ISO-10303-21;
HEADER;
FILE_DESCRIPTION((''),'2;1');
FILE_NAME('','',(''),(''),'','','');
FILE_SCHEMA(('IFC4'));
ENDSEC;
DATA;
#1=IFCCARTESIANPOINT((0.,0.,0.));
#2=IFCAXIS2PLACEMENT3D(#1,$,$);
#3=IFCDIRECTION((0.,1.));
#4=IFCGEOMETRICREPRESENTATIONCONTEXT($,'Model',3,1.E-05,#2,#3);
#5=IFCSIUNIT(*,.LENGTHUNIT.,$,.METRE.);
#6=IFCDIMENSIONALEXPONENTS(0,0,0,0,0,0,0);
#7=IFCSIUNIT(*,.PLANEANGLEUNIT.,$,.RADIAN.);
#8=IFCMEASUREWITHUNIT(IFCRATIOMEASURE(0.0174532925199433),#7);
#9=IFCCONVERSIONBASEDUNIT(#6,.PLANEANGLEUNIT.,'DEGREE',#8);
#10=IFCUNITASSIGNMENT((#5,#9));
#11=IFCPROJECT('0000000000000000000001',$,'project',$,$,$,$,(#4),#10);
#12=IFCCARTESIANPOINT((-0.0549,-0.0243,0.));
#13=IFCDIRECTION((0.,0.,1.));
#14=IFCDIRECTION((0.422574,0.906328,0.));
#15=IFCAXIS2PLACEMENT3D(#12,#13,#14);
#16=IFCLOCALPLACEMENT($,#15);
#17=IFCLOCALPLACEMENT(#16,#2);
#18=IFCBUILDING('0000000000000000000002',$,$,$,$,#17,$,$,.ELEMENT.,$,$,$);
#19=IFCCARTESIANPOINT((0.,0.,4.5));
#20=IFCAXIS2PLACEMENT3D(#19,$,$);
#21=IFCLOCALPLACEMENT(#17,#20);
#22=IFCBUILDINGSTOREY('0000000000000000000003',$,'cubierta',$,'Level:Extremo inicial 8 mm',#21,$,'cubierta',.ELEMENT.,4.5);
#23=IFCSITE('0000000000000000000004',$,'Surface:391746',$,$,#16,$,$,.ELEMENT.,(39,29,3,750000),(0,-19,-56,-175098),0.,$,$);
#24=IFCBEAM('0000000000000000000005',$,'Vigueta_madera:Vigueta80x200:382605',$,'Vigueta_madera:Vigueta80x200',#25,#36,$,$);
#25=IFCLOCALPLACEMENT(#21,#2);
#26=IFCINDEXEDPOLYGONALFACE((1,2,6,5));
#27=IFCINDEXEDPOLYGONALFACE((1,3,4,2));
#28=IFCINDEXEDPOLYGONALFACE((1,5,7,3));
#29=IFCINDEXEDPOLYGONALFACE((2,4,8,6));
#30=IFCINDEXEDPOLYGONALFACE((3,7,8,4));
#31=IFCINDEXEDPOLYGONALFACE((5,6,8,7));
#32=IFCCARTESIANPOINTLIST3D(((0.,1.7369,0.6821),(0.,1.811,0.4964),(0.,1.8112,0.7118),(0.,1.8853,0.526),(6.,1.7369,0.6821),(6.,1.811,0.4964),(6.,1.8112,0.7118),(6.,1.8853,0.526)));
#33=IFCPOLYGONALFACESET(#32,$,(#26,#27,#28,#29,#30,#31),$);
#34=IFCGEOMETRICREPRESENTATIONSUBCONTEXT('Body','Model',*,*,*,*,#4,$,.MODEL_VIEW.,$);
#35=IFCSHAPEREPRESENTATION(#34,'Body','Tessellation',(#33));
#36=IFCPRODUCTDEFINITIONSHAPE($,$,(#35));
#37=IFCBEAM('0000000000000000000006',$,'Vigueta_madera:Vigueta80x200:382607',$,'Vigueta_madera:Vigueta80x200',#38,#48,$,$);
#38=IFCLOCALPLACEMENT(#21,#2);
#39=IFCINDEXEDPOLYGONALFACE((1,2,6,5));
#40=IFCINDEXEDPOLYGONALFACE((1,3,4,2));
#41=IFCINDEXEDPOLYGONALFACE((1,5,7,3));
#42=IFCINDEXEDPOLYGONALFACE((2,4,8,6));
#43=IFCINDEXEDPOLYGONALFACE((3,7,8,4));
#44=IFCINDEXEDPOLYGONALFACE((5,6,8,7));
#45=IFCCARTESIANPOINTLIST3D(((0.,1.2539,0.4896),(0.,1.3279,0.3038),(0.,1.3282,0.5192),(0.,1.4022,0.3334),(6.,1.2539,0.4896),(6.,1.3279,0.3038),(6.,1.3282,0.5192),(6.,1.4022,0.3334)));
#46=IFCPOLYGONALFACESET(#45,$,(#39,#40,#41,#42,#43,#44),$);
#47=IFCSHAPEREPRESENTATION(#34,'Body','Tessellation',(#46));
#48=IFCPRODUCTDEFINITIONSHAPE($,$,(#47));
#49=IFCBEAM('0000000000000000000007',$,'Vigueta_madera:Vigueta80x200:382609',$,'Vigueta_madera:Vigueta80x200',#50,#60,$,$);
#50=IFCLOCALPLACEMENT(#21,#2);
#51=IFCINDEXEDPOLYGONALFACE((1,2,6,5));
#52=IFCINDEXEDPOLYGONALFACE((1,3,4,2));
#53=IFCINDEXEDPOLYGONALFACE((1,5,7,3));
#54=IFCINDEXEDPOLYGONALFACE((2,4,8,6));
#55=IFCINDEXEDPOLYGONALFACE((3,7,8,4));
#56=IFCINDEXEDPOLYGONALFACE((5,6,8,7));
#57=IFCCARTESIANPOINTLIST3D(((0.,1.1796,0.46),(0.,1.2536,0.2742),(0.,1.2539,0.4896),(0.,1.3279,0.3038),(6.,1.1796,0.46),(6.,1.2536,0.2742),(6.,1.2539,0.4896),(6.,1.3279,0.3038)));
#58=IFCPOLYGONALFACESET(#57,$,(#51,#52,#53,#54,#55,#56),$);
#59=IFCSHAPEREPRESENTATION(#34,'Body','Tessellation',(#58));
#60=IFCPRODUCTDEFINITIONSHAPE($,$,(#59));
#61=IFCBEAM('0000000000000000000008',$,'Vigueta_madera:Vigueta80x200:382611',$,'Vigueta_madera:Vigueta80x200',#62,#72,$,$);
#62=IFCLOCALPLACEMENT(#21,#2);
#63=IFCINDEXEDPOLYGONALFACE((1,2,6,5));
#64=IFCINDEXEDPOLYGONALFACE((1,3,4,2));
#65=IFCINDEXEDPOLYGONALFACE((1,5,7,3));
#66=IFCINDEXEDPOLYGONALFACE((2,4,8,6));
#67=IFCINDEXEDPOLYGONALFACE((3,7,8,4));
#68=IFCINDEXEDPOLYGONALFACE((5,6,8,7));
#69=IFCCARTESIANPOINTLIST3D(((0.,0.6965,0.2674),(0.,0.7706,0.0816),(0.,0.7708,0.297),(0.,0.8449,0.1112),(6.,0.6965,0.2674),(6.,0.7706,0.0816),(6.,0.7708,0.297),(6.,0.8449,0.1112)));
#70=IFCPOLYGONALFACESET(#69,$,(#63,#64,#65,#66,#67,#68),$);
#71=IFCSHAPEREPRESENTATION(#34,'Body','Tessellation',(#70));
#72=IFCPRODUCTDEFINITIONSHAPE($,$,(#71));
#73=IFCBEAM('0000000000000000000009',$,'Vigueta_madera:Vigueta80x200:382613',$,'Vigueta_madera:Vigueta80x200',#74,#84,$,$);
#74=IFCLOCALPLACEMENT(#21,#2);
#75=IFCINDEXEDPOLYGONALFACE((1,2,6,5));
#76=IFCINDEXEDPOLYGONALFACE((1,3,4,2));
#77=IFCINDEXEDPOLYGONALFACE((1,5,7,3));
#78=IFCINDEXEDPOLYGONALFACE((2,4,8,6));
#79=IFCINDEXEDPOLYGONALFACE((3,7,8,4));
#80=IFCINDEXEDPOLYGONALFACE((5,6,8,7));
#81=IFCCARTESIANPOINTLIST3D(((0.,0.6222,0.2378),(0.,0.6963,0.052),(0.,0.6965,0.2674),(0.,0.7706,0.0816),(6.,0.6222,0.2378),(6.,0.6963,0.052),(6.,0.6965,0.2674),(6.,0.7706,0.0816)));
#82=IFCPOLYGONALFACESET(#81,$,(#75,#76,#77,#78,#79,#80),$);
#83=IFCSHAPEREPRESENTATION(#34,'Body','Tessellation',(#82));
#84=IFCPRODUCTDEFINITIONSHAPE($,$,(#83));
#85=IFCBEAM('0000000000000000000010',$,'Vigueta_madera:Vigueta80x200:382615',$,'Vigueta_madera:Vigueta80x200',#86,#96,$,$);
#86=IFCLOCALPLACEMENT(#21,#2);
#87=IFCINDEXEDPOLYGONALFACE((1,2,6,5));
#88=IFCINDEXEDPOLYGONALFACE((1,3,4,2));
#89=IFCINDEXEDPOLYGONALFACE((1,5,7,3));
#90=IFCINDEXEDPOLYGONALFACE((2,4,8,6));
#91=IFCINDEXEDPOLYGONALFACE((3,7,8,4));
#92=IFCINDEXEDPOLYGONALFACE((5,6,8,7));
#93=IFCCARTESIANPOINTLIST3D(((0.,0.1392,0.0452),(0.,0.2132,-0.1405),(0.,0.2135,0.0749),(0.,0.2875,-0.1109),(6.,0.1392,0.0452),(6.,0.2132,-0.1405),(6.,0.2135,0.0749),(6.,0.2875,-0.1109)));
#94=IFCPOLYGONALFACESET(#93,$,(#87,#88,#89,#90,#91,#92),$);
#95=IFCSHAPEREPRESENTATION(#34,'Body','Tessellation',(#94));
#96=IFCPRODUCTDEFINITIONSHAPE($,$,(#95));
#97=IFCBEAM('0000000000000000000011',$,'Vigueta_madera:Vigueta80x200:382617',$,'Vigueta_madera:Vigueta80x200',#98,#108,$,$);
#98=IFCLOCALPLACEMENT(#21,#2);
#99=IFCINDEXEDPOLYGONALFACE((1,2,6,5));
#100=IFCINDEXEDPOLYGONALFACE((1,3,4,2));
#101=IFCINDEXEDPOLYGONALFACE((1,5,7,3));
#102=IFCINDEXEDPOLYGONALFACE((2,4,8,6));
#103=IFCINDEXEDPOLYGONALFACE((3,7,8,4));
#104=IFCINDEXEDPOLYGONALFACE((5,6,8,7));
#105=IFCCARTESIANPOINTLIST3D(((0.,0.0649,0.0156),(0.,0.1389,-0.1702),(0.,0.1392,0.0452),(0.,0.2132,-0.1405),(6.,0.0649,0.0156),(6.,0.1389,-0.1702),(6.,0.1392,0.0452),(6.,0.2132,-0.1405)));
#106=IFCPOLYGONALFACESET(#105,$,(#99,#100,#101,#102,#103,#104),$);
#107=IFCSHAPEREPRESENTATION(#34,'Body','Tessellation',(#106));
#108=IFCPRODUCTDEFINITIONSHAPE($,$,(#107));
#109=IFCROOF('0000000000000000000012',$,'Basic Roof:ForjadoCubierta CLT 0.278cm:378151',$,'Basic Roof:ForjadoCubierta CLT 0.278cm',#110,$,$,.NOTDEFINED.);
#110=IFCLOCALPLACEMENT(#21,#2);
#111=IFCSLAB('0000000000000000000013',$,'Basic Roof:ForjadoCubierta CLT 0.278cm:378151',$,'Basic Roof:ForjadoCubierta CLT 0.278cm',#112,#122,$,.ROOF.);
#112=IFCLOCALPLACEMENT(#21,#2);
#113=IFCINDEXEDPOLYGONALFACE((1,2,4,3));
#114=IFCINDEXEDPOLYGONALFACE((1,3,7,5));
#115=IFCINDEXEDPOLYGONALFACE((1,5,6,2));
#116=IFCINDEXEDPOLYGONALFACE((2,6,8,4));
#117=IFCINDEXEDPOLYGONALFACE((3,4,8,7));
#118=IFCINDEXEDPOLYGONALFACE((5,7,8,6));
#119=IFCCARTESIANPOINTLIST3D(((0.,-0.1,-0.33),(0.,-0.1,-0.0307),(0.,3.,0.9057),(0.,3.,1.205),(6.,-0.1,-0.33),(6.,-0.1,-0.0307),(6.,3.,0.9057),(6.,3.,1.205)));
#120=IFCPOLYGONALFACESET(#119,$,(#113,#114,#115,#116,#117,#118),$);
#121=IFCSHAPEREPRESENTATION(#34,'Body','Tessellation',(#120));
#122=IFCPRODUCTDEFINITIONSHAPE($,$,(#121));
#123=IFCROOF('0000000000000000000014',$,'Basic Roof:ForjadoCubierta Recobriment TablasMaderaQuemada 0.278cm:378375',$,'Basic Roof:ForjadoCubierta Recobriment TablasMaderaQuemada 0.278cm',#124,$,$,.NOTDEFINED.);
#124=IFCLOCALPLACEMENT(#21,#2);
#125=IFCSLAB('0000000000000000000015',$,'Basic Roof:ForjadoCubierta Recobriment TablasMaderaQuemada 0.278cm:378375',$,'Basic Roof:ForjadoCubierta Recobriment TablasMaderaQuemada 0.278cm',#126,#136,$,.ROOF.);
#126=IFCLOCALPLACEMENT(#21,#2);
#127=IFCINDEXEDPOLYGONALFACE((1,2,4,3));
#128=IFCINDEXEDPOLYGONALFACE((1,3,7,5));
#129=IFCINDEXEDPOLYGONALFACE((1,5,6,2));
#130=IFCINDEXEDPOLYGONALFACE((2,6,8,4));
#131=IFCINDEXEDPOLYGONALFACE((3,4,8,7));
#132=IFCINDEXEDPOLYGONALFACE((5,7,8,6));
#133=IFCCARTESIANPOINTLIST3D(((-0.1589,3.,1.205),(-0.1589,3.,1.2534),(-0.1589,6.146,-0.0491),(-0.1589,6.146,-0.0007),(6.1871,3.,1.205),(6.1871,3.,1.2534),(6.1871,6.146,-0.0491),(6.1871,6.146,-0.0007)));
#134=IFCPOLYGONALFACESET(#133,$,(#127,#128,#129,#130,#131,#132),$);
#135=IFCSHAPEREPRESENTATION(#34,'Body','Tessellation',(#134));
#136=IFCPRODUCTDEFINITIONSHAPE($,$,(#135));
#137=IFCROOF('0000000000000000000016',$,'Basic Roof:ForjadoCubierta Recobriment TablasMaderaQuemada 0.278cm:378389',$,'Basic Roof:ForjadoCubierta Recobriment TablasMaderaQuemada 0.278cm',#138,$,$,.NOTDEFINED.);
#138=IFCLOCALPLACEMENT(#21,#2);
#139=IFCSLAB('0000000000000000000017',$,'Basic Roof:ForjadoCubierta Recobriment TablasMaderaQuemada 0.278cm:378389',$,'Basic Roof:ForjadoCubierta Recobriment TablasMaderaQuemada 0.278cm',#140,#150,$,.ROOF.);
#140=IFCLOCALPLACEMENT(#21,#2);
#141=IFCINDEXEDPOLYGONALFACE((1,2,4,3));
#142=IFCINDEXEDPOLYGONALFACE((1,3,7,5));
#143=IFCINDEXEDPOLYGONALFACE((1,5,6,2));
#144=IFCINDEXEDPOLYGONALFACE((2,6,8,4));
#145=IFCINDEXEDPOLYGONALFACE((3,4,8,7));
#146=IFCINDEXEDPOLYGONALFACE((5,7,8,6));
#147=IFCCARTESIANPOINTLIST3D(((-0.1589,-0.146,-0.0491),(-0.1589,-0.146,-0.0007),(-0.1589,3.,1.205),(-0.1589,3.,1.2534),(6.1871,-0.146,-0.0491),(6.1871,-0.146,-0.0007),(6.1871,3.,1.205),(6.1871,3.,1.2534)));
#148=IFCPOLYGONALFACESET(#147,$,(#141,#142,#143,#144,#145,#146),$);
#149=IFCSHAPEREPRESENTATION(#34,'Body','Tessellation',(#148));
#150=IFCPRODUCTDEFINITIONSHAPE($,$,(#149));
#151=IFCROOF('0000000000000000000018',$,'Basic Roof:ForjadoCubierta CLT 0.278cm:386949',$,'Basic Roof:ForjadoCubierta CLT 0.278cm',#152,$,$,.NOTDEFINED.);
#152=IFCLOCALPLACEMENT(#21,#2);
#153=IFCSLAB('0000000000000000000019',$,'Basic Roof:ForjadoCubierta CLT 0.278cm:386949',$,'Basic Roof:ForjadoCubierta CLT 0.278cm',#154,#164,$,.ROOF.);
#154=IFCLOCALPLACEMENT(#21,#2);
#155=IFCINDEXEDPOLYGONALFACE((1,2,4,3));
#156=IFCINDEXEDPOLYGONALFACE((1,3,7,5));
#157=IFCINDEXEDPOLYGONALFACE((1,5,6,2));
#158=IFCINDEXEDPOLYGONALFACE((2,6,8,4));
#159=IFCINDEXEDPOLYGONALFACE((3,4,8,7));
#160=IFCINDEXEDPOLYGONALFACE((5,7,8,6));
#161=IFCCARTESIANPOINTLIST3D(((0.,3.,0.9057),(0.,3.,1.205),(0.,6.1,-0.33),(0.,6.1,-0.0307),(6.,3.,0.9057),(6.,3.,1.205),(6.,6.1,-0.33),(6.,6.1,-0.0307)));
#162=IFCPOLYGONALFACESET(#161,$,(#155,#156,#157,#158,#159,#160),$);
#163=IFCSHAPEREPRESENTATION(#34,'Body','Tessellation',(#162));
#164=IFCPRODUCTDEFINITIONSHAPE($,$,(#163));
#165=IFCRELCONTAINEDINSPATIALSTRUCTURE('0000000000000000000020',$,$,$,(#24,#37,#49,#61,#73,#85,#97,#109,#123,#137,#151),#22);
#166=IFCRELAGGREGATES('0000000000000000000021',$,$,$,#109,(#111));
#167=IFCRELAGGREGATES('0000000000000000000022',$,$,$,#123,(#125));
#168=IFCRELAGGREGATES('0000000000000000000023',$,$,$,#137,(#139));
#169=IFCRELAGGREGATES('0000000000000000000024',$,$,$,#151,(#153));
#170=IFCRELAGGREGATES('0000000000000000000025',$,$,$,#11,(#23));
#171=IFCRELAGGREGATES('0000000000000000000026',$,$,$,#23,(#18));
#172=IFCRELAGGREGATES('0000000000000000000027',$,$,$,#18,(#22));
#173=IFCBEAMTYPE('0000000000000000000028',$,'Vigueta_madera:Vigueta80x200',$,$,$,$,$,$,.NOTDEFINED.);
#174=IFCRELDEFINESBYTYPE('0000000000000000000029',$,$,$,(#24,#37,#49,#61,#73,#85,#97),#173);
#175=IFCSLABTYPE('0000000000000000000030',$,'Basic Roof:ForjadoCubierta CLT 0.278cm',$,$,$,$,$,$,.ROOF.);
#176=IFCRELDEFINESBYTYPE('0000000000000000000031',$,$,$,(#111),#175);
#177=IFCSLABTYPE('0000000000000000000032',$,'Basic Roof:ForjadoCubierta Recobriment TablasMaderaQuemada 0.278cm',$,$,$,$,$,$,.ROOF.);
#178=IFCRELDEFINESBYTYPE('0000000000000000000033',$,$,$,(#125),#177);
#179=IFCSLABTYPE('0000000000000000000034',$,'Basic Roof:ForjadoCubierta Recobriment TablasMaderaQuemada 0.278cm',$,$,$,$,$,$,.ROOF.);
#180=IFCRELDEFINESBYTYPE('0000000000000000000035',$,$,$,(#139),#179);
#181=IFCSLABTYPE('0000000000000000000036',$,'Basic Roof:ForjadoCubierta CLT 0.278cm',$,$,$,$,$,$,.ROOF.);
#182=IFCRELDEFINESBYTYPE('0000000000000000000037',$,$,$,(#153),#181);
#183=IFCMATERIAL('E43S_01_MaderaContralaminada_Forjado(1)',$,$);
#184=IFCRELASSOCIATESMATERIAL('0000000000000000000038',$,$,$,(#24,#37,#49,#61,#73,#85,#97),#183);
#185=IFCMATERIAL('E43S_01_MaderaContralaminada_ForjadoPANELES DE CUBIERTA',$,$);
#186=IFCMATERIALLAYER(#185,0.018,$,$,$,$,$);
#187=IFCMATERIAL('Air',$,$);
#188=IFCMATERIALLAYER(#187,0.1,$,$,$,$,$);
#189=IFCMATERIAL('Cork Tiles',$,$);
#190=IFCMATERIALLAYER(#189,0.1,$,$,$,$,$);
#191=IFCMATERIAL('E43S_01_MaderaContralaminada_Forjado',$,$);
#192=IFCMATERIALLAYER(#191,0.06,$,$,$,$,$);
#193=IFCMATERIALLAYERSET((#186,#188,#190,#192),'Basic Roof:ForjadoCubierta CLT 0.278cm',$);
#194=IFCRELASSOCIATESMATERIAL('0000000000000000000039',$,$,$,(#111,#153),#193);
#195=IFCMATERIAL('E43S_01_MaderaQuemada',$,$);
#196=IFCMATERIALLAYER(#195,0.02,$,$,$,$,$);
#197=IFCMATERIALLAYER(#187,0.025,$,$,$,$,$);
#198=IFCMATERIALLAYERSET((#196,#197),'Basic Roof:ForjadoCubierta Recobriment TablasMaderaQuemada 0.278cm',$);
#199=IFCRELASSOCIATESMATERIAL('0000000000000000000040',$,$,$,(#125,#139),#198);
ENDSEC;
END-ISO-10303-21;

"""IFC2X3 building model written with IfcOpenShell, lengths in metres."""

from ifc_helpers import new_model, entity, si_unit, converted_unit, direction, frame, frame_2d, origin, place, context, subcontext, project, spatial, rectangle, extrude, material, layer, layer_set, type_object, element, aggregate, save


model = new_model("IFC2X3")

# Units and contexts
model_context = context("Model", 3, precision=1e-05, world=origin(), true_north=direction((0.0, 1.0)))
body_context = subcontext(model_context, "Body", "Model", "MODEL_VIEW")
ifc_project = project(units=[si_unit("LENGTHUNIT", "METRE"), converted_unit("PLANEANGLEUNIT", "DEGREE", entity("IfcRatioMeasure", 0.0174532925199433), si_unit("PLANEANGLEUNIT", "RADIAN"), dimensions=[0, 0, 0, 0, 0, 0, 0])], contexts=[model_context])

# Site, building, storey
site_placement = place(None, frame((-0.0549, -0.0243, 0.0), z_axis=(0.0, 0.0, 1.0), x_axis=(0.422574, 0.906328, 0.0)))
site = spatial("IfcSite", under=ifc_project, at=site_placement, Name="Surface:391746", CompositionType="ELEMENT", RefLatitude=(39, 29, 3, 750000), RefLongitude=(0, -19, -56, -175098), RefElevation=0.0)
building_placement = place(site_placement, origin())
building = spatial("IfcBuilding", under=site, at=building_placement, CompositionType="ELEMENT")
storey_placement = place(building_placement, frame((0.0, 0.0, 4.5)))
storey = spatial("IfcBuildingStorey", under=building, at=storey_placement, Name="cubierta", ObjectType="Level:Extremo inicial 8 mm", LongName="cubierta", CompositionType="ELEMENT", Elevation=4.5)

# Beams
ifc_material_1 = material(Name="E43S_01_MaderaContralaminada_Forjado(1)")
beam_type = type_object("IfcBeamType", Name="Vigueta_madera:Vigueta80x200", PredefinedType="NOTDEFINED")
beam_1_placement = place(storey_placement, frame((0.0, 1.7741, 0.697)))
element("IfcBeam", 1, at=beam_1_placement, inside=storey, type_object=beam_type, material=ifc_material_1, Name="Vigueta_madera:Vigueta80x200:382605", ObjectType="Vigueta_madera:Vigueta80x200", context=body_context, shape_type="SweptSolid", body=[
    extrude(rectangle(XDim=0.2, YDim=0.08, at=frame_2d((0.0, 0.0), x_axis=(1.0, 0.0))), frame((0.0, 0.037, -0.0929), z_axis=(1.0, 0.0, 0.0), x_axis=(0.0, -0.370233, 0.928939)), (0.0, 0.0, 1.0), 6.0),
])
beam_2_placement = place(storey_placement, frame((0.0, 1.291, 0.5044)))
element("IfcBeam", 2, at=beam_2_placement, inside=storey, type_object=beam_type, material=ifc_material_1, Name="Vigueta_madera:Vigueta80x200:382607", ObjectType="Vigueta_madera:Vigueta80x200", context=body_context, shape_type="SweptSolid", body=[
    extrude(rectangle(XDim=0.2, YDim=0.08, at=frame_2d((0.0, 0.0), x_axis=(1.0, 0.0))), frame((0.0, 0.037, -0.0929), z_axis=(1.0, 0.0, 0.0), x_axis=(0.0, -0.370233, 0.928939)), (0.0, 0.0, 1.0), 6.0),
])
beam_3_placement = place(storey_placement, frame((0.0, 1.2167, 0.4748)))
element("IfcBeam", 3, at=beam_3_placement, inside=storey, type_object=beam_type, material=ifc_material_1, Name="Vigueta_madera:Vigueta80x200:382609", ObjectType="Vigueta_madera:Vigueta80x200", context=body_context, shape_type="SweptSolid", body=[
    extrude(rectangle(XDim=0.2, YDim=0.08, at=frame_2d((0.0, 0.0), x_axis=(1.0, 0.0))), frame((0.0, 0.037, -0.0929), z_axis=(1.0, 0.0, 0.0), x_axis=(0.0, -0.370233, 0.928939)), (0.0, 0.0, 1.0), 6.0),
])
beam_4_placement = place(storey_placement, frame((0.0, 0.7337, 0.2822)))
element("IfcBeam", 4, at=beam_4_placement, inside=storey, type_object=beam_type, material=ifc_material_1, Name="Vigueta_madera:Vigueta80x200:382611", ObjectType="Vigueta_madera:Vigueta80x200", context=body_context, shape_type="SweptSolid", body=[
    extrude(rectangle(XDim=0.2, YDim=0.08, at=frame_2d((0.0, 0.0), x_axis=(1.0, 0.0))), frame((0.0, 0.037, -0.0929), z_axis=(1.0, 0.0, 0.0), x_axis=(0.0, -0.370233, 0.928939)), (0.0, 0.0, 1.0), 6.0),
])
beam_5_placement = place(storey_placement, frame((0.0, 0.6594, 0.2526)))
element("IfcBeam", 5, at=beam_5_placement, inside=storey, type_object=beam_type, material=ifc_material_1, Name="Vigueta_madera:Vigueta80x200:382613", ObjectType="Vigueta_madera:Vigueta80x200", context=body_context, shape_type="SweptSolid", body=[
    extrude(rectangle(XDim=0.2, YDim=0.08, at=frame_2d((0.0, 0.0), x_axis=(1.0, 0.0))), frame((0.0, 0.037, -0.0929), z_axis=(1.0, 0.0, 0.0), x_axis=(0.0, -0.370233, 0.928939)), (0.0, 0.0, 1.0), 6.0),
])
beam_6_placement = place(storey_placement, frame((0.0, 0.1763, 0.0601)))
element("IfcBeam", 6, at=beam_6_placement, inside=storey, type_object=beam_type, material=ifc_material_1, Name="Vigueta_madera:Vigueta80x200:382615", ObjectType="Vigueta_madera:Vigueta80x200", context=body_context, shape_type="SweptSolid", body=[
    extrude(rectangle(XDim=0.2, YDim=0.08, at=frame_2d((0.0, 0.0), x_axis=(1.0, 0.0))), frame((0.0, 0.037, -0.0929), z_axis=(1.0, 0.0, 0.0), x_axis=(0.0, -0.370233, 0.928939)), (0.0, 0.0, 1.0), 6.0),
])
beam_7_placement = place(storey_placement, frame((0.0, 0.102, 0.0304)))
element("IfcBeam", 7, at=beam_7_placement, inside=storey, type_object=beam_type, material=ifc_material_1, Name="Vigueta_madera:Vigueta80x200:382617", ObjectType="Vigueta_madera:Vigueta80x200", context=body_context, shape_type="SweptSolid", body=[
    extrude(rectangle(XDim=0.2, YDim=0.08, at=frame_2d((0.0, 0.0), x_axis=(1.0, 0.0))), frame((0.0, 0.037, -0.0929), z_axis=(1.0, 0.0, 0.0), x_axis=(0.0, -0.370233, 0.928939)), (0.0, 0.0, 1.0), 6.0),
])

# Roofs, slabs
roof_1_placement = place(storey_placement, frame((0.0, -0.1, -0.33)))
roof_1 = element("IfcRoof", 8, at=roof_1_placement, inside=storey, Name="Basic Roof:ForjadoCubierta CLT 0.278cm:378151", ObjectType="Basic Roof:ForjadoCubierta CLT 0.278cm", ShapeType="NOTDEFINED")
ifc_material_2 = material(Name="E43S_01_MaderaContralaminada_ForjadoPANELES DE CUBIERTA")
ifc_layer_1 = layer(ifc_material_2, 0.018)
ifc_material_3 = material(Name="Air")
ifc_layer_2 = layer(ifc_material_3, 0.1)
ifc_material_4 = material(Name="Cork Tiles")
ifc_layer_3 = layer(ifc_material_4, 0.1)
ifc_material_5 = material(Name="E43S_01_MaderaContralaminada_Forjado")
ifc_layer_4 = layer(ifc_material_5, 0.06)
ifc_layer_set_1 = layer_set([ifc_layer_1, ifc_layer_2, ifc_layer_3, ifc_layer_4], Name="Basic Roof:ForjadoCubierta CLT 0.278cm")
slab_type_1 = type_object("IfcSlabType", Name="Basic Roof:ForjadoCubierta CLT 0.278cm", PredefinedType="ROOF")
slab_1_placement = place(roof_1_placement, origin())
slab_1 = element("IfcSlab", 9, at=slab_1_placement, type_object=slab_type_1, material=ifc_layer_set_1, Name="Basic Roof:ForjadoCubierta CLT 0.278cm:378151", ObjectType="Basic Roof:ForjadoCubierta CLT 0.278cm", PredefinedType="ROOF", context=body_context, shape_type="SweptSolid", body=[
    extrude(rectangle(XDim=3.3372, YDim=6.0, at=frame_2d((0.0, 0.0), x_axis=(0.0, -1.0))), frame((3.0, 1.55, 0.6179), z_axis=(0.0, -0.370288, 0.928917), x_axis=(1.0, 0.0, 0.0)), (0.0, 0.370288, 0.928917), 0.2993),
])
aggregate(roof_1, [slab_1])
roof_2_placement = place(storey_placement, frame((-0.1589, 3.0, -0.0491)))
roof_2 = element("IfcRoof", 10, at=roof_2_placement, inside=storey, Name="Basic Roof:ForjadoCubierta Recobriment TablasMaderaQuemada 0.278cm:378375", ObjectType="Basic Roof:ForjadoCubierta Recobriment TablasMaderaQuemada 0.278cm", ShapeType="NOTDEFINED")
ifc_material_6 = material(Name="E43S_01_MaderaQuemada")
ifc_layer_5 = layer(ifc_material_6, 0.02)
ifc_layer_6 = layer(ifc_material_3, 0.025)
ifc_layer_set_2 = layer_set([ifc_layer_5, ifc_layer_6], Name="Basic Roof:ForjadoCubierta Recobriment TablasMaderaQuemada 0.278cm")
slab_type_2 = type_object("IfcSlabType", Name="Basic Roof:ForjadoCubierta Recobriment TablasMaderaQuemada 0.278cm", PredefinedType="ROOF")
slab_2_placement = place(roof_2_placement, origin())
slab_2 = element("IfcSlab", 11, at=slab_2_placement, type_object=slab_type_2, material=ifc_layer_set_2, Name="Basic Roof:ForjadoCubierta Recobriment TablasMaderaQuemada 0.278cm:378375", ObjectType="Basic Roof:ForjadoCubierta Recobriment TablasMaderaQuemada 0.278cm", PredefinedType="ROOF", context=body_context, shape_type="SweptSolid", body=[
    extrude(rectangle(XDim=3.3867, YDim=6.346, at=frame_2d((0.0, 0.0), x_axis=(0.0, 1.0))), frame((3.173, 1.573, 0.627), z_axis=(0.0, 0.370288, 0.928917), x_axis=(1.0, 0.0, 0.0)), (0.0, -0.370288, 0.928917), 0.0484),
])
aggregate(roof_2, [slab_2])
roof_3_placement = place(storey_placement, frame((-0.1589, -0.146, -0.0491)))
roof_3 = element("IfcRoof", 12, at=roof_3_placement, inside=storey, Name="Basic Roof:ForjadoCubierta Recobriment TablasMaderaQuemada 0.278cm:378389", ObjectType="Basic Roof:ForjadoCubierta Recobriment TablasMaderaQuemada 0.278cm", ShapeType="NOTDEFINED")
slab_type_3 = type_object("IfcSlabType", Name="Basic Roof:ForjadoCubierta Recobriment TablasMaderaQuemada 0.278cm", PredefinedType="ROOF")
slab_3_placement = place(roof_3_placement, origin())
slab_3 = element("IfcSlab", 13, at=slab_3_placement, type_object=slab_type_3, material=ifc_layer_set_2, Name="Basic Roof:ForjadoCubierta Recobriment TablasMaderaQuemada 0.278cm:378389", ObjectType="Basic Roof:ForjadoCubierta Recobriment TablasMaderaQuemada 0.278cm", PredefinedType="ROOF", context=body_context, shape_type="SweptSolid", body=[
    extrude(rectangle(XDim=3.3867, YDim=6.346, at=frame_2d((0.0, 0.0), x_axis=(0.0, -1.0))), frame((3.173, 1.573, 0.627), z_axis=(0.0, -0.370288, 0.928917), x_axis=(1.0, 0.0, 0.0)), (0.0, 0.370288, 0.928917), 0.0484),
])
aggregate(roof_3, [slab_3])
roof_4_placement = place(storey_placement, frame((0.0, 3.0, -0.33)))
roof_4 = element("IfcRoof", 14, at=roof_4_placement, inside=storey, Name="Basic Roof:ForjadoCubierta CLT 0.278cm:386949", ObjectType="Basic Roof:ForjadoCubierta CLT 0.278cm", ShapeType="NOTDEFINED")
slab_type_4 = type_object("IfcSlabType", Name="Basic Roof:ForjadoCubierta CLT 0.278cm", PredefinedType="ROOF")
slab_4_placement = place(roof_4_placement, origin())
slab_4 = element("IfcSlab", 15, at=slab_4_placement, type_object=slab_type_4, material=ifc_layer_set_1, Name="Basic Roof:ForjadoCubierta CLT 0.278cm:386949", ObjectType="Basic Roof:ForjadoCubierta CLT 0.278cm", PredefinedType="ROOF", context=body_context, shape_type="SweptSolid", body=[
    extrude(rectangle(XDim=3.3372, YDim=6.0, at=frame_2d((0.0, 0.0), x_axis=(0.0, 1.0))), frame((3.0, 1.55, 0.6179), z_axis=(0.0, 0.370288, 0.928917), x_axis=(1.0, 0.0, 0.0)), (0.0, -0.370288, 0.928917), 0.2993),
])
aggregate(roof_4, [slab_4])

save(model, "model.ifc")
